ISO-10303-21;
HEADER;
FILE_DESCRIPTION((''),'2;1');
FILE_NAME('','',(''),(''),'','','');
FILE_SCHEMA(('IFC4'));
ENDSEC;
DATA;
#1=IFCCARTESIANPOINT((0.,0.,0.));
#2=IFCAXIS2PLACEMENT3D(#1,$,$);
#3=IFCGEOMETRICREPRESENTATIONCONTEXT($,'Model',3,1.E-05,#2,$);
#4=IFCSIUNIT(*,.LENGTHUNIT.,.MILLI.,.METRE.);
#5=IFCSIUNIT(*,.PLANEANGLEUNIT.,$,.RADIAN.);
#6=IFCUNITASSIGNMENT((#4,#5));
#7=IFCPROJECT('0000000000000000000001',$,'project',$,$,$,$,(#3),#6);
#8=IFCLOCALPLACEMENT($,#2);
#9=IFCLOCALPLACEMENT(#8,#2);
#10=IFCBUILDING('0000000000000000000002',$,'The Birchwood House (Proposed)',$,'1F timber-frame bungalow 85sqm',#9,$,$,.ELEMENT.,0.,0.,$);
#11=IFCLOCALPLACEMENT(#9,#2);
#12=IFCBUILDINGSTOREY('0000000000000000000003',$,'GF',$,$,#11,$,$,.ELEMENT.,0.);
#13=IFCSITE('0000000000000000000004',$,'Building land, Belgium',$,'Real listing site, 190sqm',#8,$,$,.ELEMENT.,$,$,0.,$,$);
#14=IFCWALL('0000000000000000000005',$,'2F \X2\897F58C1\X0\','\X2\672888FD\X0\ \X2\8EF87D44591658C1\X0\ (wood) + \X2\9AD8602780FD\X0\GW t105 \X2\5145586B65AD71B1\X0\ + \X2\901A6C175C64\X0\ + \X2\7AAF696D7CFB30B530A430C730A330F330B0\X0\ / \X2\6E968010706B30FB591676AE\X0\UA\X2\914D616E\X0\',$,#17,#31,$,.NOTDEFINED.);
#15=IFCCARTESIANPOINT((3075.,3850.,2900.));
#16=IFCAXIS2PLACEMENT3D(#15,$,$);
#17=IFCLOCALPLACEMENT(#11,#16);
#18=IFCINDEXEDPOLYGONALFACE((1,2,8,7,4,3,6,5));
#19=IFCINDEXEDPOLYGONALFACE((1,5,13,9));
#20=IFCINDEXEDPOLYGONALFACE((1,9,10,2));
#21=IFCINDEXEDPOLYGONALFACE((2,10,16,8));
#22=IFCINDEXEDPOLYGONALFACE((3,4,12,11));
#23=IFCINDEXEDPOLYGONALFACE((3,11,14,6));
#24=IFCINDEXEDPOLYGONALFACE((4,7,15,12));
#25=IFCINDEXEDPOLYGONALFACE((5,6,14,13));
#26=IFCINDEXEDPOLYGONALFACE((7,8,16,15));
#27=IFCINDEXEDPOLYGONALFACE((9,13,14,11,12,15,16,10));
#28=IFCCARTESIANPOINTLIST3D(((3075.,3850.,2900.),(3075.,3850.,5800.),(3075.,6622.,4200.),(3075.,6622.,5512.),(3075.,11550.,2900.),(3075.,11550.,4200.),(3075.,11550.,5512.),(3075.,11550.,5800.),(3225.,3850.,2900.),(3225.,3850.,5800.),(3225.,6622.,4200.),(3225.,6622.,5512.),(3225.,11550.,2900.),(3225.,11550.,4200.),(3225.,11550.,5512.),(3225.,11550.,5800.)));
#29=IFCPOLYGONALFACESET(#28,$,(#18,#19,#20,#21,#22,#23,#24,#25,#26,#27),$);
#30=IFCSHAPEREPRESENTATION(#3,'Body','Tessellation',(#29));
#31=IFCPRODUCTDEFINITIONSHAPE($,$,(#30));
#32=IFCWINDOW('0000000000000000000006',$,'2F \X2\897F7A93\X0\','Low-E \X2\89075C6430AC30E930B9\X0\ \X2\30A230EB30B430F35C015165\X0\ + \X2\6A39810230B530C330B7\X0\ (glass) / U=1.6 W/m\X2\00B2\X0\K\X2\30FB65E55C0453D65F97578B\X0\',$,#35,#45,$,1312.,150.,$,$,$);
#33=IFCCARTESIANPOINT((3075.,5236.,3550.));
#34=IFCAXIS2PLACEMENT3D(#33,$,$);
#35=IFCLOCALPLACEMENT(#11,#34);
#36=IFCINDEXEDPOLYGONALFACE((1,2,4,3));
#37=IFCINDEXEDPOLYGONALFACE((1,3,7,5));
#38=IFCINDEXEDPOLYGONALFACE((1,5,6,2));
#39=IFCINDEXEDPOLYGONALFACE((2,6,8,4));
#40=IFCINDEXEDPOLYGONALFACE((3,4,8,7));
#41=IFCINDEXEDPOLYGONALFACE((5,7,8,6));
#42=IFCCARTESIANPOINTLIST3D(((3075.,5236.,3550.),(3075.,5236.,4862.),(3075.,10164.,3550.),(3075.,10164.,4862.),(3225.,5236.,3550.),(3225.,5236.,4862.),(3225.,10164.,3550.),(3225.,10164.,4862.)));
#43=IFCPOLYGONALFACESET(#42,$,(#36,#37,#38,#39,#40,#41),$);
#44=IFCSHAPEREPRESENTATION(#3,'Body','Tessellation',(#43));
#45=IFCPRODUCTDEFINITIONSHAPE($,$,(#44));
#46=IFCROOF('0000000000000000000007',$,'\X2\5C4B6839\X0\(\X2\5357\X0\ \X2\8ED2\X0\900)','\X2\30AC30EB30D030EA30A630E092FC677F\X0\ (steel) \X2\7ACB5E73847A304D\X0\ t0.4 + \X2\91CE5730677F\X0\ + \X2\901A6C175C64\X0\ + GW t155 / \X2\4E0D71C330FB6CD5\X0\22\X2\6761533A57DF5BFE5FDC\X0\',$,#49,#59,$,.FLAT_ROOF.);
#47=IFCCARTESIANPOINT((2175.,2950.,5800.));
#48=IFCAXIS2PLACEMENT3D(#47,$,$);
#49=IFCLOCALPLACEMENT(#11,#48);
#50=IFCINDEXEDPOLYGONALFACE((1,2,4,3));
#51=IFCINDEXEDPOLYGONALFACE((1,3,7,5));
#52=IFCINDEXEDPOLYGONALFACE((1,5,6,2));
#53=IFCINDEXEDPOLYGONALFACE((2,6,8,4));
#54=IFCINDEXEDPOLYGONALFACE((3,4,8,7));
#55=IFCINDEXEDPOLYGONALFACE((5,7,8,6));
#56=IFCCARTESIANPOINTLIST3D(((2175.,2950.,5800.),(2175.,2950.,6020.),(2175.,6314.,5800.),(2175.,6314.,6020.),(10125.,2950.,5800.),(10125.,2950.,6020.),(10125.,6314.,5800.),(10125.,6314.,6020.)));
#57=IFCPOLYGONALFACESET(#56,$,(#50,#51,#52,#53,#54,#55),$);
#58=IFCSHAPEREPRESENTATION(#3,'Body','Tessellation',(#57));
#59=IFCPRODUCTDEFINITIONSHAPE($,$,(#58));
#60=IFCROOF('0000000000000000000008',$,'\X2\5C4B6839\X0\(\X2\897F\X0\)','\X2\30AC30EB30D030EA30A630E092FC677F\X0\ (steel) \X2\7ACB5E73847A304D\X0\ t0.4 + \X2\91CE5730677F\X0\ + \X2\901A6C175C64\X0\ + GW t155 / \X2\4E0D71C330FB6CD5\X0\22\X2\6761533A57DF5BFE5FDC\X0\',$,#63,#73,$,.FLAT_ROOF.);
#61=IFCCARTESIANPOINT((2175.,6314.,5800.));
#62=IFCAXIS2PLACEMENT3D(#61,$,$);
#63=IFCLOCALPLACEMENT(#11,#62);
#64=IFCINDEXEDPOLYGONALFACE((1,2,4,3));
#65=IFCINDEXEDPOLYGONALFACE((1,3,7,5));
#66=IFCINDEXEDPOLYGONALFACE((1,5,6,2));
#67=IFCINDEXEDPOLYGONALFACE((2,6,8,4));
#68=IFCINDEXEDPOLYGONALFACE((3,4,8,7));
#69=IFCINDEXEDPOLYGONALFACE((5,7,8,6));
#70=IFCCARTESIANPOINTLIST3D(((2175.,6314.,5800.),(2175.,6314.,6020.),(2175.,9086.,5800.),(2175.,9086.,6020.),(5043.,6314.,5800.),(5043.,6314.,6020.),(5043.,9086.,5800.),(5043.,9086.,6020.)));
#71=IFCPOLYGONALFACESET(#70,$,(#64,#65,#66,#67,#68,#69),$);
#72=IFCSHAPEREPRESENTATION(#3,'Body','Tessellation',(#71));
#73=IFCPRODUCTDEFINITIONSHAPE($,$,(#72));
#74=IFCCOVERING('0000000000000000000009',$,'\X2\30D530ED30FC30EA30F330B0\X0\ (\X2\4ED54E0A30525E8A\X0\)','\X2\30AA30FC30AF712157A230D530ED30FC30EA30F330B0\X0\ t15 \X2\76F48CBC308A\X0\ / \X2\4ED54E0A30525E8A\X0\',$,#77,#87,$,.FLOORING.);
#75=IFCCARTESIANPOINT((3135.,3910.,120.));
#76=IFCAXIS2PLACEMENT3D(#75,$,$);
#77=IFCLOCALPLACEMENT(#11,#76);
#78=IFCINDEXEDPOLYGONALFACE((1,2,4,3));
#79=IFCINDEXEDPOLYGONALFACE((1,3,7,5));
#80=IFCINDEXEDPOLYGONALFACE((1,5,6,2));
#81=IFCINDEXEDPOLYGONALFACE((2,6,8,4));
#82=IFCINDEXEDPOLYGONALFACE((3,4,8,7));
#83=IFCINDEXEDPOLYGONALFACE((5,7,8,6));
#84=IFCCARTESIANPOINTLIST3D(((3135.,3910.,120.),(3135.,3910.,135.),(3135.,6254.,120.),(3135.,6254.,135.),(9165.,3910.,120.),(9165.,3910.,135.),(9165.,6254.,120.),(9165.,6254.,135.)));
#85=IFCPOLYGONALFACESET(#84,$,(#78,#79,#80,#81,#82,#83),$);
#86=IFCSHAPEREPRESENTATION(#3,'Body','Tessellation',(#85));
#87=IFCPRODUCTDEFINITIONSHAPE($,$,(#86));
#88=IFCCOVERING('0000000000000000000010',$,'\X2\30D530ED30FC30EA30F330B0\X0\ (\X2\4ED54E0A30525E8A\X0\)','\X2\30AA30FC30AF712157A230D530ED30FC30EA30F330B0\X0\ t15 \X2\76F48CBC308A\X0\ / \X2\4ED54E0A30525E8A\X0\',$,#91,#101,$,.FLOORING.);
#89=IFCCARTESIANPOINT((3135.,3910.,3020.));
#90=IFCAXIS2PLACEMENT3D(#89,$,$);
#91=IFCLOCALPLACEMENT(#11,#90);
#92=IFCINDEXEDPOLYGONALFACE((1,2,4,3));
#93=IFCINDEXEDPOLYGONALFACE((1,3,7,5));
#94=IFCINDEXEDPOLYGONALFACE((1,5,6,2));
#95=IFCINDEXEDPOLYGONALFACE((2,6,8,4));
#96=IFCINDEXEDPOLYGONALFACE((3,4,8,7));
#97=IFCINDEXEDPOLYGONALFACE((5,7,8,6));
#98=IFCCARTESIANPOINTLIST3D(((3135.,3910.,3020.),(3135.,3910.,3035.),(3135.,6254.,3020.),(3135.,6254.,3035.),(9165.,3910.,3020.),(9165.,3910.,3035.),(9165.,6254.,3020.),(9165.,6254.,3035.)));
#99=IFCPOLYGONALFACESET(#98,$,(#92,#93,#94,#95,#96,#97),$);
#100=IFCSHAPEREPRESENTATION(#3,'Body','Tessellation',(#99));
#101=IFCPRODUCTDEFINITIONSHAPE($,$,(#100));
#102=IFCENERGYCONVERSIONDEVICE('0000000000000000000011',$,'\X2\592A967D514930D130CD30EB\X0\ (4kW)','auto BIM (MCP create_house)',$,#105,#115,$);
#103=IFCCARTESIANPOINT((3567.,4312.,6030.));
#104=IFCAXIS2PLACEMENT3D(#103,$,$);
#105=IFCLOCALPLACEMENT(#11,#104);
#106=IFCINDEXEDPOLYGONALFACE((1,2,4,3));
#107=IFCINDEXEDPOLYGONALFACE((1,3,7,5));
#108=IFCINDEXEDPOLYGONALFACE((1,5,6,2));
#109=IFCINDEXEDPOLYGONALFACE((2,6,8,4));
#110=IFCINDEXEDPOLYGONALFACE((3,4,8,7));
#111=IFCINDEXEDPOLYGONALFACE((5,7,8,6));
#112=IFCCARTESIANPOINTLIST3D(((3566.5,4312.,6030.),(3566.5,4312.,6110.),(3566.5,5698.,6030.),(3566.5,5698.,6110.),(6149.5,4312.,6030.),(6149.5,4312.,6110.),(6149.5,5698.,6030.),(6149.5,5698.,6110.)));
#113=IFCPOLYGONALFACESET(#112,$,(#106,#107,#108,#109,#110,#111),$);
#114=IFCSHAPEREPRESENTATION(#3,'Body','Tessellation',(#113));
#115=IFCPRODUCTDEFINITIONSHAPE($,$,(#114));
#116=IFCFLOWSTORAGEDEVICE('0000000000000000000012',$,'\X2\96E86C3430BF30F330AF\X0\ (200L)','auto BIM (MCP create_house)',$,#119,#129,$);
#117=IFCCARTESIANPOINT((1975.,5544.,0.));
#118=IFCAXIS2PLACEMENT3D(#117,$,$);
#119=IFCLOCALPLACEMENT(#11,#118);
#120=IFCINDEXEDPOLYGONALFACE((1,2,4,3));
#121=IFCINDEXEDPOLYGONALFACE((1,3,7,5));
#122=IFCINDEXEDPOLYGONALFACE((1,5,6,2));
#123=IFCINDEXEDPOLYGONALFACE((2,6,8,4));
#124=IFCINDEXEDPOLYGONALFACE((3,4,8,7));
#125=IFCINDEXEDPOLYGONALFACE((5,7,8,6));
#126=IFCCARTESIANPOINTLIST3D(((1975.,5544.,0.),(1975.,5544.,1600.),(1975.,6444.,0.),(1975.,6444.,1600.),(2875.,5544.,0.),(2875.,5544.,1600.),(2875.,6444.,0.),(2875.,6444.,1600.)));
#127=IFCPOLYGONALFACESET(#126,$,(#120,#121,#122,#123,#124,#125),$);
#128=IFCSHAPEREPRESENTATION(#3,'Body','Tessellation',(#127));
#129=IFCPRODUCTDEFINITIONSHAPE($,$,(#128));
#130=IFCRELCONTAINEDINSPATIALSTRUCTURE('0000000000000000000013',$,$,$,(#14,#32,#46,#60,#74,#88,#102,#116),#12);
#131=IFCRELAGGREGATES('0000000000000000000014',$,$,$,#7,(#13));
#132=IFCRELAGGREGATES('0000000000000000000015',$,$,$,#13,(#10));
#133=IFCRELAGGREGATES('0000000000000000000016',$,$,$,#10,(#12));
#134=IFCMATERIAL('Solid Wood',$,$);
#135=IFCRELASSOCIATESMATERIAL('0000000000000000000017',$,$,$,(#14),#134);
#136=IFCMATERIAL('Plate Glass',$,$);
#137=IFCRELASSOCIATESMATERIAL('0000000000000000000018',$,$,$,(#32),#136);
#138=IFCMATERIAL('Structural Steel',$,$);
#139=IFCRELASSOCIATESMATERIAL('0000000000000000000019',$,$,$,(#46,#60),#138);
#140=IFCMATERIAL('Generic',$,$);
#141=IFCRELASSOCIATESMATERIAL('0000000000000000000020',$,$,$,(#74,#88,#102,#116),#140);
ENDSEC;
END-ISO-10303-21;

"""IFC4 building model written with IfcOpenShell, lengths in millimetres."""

from ifc_helpers import new_model, si_unit, frame, frame_2d, origin, place, context, project, spatial, rectangle, extrude, material, element, fill, save


model = new_model("IFC4")

# Units and contexts
model_context = context("Model", 3, precision=1e-05, world=origin())
ifc_project = project(units=[si_unit("LENGTHUNIT", "METRE", prefix="MILLI"), si_unit("PLANEANGLEUNIT", "RADIAN")], contexts=[model_context])

# Site, building, storey
site_placement = place(None, origin())
site = spatial("IfcSite", under=ifc_project, at=site_placement, Name="Building land, Belgium", ObjectType="Real listing site, 190sqm", CompositionType="ELEMENT", RefElevation=0.0)
building_placement = place(site_placement, origin())
building = spatial("IfcBuilding", under=site, at=building_placement, Name="The Birchwood House (Proposed)", ObjectType="1F timber-frame bungalow 85sqm", CompositionType="ELEMENT", ElevationOfRefHeight=0.0, ElevationOfTerrain=0.0)
storey_placement = place(building_placement, origin())
storey = spatial("IfcBuildingStorey", under=building, at=storey_placement, Name="GF", CompositionType="ELEMENT", Elevation=0.0)

# Shared definitions
ifc_material_1 = material(Name="Solid Wood")
ifc_material_2 = material(Name="Generic")

# Shared definitions
ifc_material_3 = material(Name="Plate Glass")

# Wall, opening, window
wall_1_placement = place(storey_placement, frame((3075.0, 3850.0, 2900.0)))
wall_1 = element("IfcWall", 1, at=wall_1_placement, inside=storey, material=ifc_material_1, Name="2F 西壁", Description="木製 軸組外壁 (wood) + 高性能GW t105 充填断熱 + 通気層 + 窯業系サイディング / 準耐火・外皮UA配慮", PredefinedType="NOTDEFINED", context=model_context, shape_type="SweptSolid", body=[
    extrude(rectangle(XDim=150.0, YDim=7700.0, at=frame_2d((75.0, 3850.0))), frame((3075.0, 3850.0, 2900.0)), (0.0, 0.0, 1.0), 2900.0),
])
opening_1_placement = place(storey_placement, frame((3075.0, 5236.0, 3550.0)))
opening_1 = element("IfcOpeningElement", 2, at=opening_1_placement, cuts=wall_1, PredefinedType="NOTDEFINED", context=model_context, shape_type="SweptSolid", body=[
    extrude(rectangle(XDim=150.0, YDim=4928.0, at=frame_2d((75.0, 2464.0))), frame((3075.0, 5236.0, 3550.0)), (0.0, 0.0, 1.0), 1312.0),
])
window_1_placement = place(storey_placement, frame((3075.0, 5236.0, 3550.0)))
window_1 = element("IfcWindow", 3, at=window_1_placement, inside=storey, material=ifc_material_3, Name="2F 西窓", Description="Low-E 複層ガラス アルゴン封入 + 樹脂サッシ (glass) / U=1.6 W/m²K・日射取得型", OverallHeight=1312.0, OverallWidth=150.0, context=model_context, shape_type="SweptSolid", body=[
    extrude(rectangle(XDim=150.0, YDim=4928.0, at=frame_2d((75.0, 2464.0))), frame((3075.0, 5236.0, 3550.0)), (0.0, 0.0, 1.0), 1312.0),
])
fill(opening_1, window_1)

# Roofs
ifc_material_4 = material(Name="Structural Steel")
roof_1_placement = place(storey_placement, frame((2175.0, 2950.0, 5800.0)))
element("IfcRoof", 4, at=roof_1_placement, inside=storey, material=ifc_material_4, Name="屋根(南 軒900)", Description="ガルバリウム鋼板 (steel) 立平葺き t0.4 + 野地板 + 通気層 + GW t155 / 不燃・法22条区域対応", PredefinedType="FLAT_ROOF", context=model_context, shape_type="SweptSolid", body=[
    extrude(rectangle(XDim=7950.0, YDim=3364.0, at=frame_2d((3975.0, 1682.0))), frame((2175.0, 2950.0, 5800.0)), (0.0, 0.0, 1.0), 220.0),
])
roof_2_placement = place(storey_placement, frame((2175.0, 6314.0, 5800.0)))
element("IfcRoof", 5, at=roof_2_placement, inside=storey, material=ifc_material_4, Name="屋根(西)", Description="ガルバリウム鋼板 (steel) 立平葺き t0.4 + 野地板 + 通気層 + GW t155 / 不燃・法22条区域対応", PredefinedType="FLAT_ROOF", context=model_context, shape_type="SweptSolid", body=[
    extrude(rectangle(XDim=2868.0, YDim=2772.0, at=frame_2d((1434.0, 1386.0))), frame((2175.0, 6314.0, 5800.0)), (0.0, 0.0, 1.0), 220.0),
])

# Coverings
covering_1_placement = place(storey_placement, frame((3135.0, 3910.0, 120.0)))
element("IfcCovering", 6, at=covering_1_placement, inside=storey, material=ifc_material_2, Name="フローリング (仕上げ床)", Description="オーク無垢フローリング t15 直貼り / 仕上げ床", PredefinedType="FLOORING", context=model_context, shape_type="SweptSolid", body=[
    extrude(rectangle(XDim=6030.0, YDim=2344.0, at=frame_2d((3015.0, 1172.0))), frame((3135.0, 3910.0, 120.0)), (0.0, 0.0, 1.0), 15.0),
])
covering_2_placement = place(storey_placement, frame((3135.0, 3910.0, 3020.0)))
element("IfcCovering", 7, at=covering_2_placement, inside=storey, material=ifc_material_2, Name="フローリング (仕上げ床)", Description="オーク無垢フローリング t15 直貼り / 仕上げ床", PredefinedType="FLOORING", context=model_context, shape_type="SweptSolid", body=[
    extrude(rectangle(XDim=6030.0, YDim=2344.0, at=frame_2d((3015.0, 1172.0))), frame((3135.0, 3910.0, 3020.0)), (0.0, 0.0, 1.0), 15.0),
])

# Energy conversion device
energy_conversion_device_placement = place(storey_placement, frame((3567.0, 4312.0, 6030.0)))
element("IfcEnergyConversionDevice", 8, at=energy_conversion_device_placement, inside=storey, material=ifc_material_2, Name="太陽光パネル (4kW)", Description="auto BIM (MCP create_house)", context=model_context, shape_type="SweptSolid", body=[
    extrude(rectangle(XDim=2583.0, YDim=1386.0, at=frame_2d((1291.0, 693.0))), frame((3567.0, 4312.0, 6030.0)), (0.0, 0.0, 1.0), 80.0),
])

# Flow storage device
flow_storage_device_placement = place(storey_placement, frame((1975.0, 5544.0, 0.0)))
element("IfcFlowStorageDevice", 9, at=flow_storage_device_placement, inside=storey, material=ifc_material_2, Name="雨水タンク (200L)", Description="auto BIM (MCP create_house)", context=model_context, shape_type="SweptSolid", body=[
    extrude(rectangle(XDim=900.0, YDim=900.0, at=frame_2d((450.0, 450.0))), frame((1975.0, 5544.0, 0.0)), (0.0, 0.0, 1.0), 1600.0),
])

save(model, "model.ifc")
